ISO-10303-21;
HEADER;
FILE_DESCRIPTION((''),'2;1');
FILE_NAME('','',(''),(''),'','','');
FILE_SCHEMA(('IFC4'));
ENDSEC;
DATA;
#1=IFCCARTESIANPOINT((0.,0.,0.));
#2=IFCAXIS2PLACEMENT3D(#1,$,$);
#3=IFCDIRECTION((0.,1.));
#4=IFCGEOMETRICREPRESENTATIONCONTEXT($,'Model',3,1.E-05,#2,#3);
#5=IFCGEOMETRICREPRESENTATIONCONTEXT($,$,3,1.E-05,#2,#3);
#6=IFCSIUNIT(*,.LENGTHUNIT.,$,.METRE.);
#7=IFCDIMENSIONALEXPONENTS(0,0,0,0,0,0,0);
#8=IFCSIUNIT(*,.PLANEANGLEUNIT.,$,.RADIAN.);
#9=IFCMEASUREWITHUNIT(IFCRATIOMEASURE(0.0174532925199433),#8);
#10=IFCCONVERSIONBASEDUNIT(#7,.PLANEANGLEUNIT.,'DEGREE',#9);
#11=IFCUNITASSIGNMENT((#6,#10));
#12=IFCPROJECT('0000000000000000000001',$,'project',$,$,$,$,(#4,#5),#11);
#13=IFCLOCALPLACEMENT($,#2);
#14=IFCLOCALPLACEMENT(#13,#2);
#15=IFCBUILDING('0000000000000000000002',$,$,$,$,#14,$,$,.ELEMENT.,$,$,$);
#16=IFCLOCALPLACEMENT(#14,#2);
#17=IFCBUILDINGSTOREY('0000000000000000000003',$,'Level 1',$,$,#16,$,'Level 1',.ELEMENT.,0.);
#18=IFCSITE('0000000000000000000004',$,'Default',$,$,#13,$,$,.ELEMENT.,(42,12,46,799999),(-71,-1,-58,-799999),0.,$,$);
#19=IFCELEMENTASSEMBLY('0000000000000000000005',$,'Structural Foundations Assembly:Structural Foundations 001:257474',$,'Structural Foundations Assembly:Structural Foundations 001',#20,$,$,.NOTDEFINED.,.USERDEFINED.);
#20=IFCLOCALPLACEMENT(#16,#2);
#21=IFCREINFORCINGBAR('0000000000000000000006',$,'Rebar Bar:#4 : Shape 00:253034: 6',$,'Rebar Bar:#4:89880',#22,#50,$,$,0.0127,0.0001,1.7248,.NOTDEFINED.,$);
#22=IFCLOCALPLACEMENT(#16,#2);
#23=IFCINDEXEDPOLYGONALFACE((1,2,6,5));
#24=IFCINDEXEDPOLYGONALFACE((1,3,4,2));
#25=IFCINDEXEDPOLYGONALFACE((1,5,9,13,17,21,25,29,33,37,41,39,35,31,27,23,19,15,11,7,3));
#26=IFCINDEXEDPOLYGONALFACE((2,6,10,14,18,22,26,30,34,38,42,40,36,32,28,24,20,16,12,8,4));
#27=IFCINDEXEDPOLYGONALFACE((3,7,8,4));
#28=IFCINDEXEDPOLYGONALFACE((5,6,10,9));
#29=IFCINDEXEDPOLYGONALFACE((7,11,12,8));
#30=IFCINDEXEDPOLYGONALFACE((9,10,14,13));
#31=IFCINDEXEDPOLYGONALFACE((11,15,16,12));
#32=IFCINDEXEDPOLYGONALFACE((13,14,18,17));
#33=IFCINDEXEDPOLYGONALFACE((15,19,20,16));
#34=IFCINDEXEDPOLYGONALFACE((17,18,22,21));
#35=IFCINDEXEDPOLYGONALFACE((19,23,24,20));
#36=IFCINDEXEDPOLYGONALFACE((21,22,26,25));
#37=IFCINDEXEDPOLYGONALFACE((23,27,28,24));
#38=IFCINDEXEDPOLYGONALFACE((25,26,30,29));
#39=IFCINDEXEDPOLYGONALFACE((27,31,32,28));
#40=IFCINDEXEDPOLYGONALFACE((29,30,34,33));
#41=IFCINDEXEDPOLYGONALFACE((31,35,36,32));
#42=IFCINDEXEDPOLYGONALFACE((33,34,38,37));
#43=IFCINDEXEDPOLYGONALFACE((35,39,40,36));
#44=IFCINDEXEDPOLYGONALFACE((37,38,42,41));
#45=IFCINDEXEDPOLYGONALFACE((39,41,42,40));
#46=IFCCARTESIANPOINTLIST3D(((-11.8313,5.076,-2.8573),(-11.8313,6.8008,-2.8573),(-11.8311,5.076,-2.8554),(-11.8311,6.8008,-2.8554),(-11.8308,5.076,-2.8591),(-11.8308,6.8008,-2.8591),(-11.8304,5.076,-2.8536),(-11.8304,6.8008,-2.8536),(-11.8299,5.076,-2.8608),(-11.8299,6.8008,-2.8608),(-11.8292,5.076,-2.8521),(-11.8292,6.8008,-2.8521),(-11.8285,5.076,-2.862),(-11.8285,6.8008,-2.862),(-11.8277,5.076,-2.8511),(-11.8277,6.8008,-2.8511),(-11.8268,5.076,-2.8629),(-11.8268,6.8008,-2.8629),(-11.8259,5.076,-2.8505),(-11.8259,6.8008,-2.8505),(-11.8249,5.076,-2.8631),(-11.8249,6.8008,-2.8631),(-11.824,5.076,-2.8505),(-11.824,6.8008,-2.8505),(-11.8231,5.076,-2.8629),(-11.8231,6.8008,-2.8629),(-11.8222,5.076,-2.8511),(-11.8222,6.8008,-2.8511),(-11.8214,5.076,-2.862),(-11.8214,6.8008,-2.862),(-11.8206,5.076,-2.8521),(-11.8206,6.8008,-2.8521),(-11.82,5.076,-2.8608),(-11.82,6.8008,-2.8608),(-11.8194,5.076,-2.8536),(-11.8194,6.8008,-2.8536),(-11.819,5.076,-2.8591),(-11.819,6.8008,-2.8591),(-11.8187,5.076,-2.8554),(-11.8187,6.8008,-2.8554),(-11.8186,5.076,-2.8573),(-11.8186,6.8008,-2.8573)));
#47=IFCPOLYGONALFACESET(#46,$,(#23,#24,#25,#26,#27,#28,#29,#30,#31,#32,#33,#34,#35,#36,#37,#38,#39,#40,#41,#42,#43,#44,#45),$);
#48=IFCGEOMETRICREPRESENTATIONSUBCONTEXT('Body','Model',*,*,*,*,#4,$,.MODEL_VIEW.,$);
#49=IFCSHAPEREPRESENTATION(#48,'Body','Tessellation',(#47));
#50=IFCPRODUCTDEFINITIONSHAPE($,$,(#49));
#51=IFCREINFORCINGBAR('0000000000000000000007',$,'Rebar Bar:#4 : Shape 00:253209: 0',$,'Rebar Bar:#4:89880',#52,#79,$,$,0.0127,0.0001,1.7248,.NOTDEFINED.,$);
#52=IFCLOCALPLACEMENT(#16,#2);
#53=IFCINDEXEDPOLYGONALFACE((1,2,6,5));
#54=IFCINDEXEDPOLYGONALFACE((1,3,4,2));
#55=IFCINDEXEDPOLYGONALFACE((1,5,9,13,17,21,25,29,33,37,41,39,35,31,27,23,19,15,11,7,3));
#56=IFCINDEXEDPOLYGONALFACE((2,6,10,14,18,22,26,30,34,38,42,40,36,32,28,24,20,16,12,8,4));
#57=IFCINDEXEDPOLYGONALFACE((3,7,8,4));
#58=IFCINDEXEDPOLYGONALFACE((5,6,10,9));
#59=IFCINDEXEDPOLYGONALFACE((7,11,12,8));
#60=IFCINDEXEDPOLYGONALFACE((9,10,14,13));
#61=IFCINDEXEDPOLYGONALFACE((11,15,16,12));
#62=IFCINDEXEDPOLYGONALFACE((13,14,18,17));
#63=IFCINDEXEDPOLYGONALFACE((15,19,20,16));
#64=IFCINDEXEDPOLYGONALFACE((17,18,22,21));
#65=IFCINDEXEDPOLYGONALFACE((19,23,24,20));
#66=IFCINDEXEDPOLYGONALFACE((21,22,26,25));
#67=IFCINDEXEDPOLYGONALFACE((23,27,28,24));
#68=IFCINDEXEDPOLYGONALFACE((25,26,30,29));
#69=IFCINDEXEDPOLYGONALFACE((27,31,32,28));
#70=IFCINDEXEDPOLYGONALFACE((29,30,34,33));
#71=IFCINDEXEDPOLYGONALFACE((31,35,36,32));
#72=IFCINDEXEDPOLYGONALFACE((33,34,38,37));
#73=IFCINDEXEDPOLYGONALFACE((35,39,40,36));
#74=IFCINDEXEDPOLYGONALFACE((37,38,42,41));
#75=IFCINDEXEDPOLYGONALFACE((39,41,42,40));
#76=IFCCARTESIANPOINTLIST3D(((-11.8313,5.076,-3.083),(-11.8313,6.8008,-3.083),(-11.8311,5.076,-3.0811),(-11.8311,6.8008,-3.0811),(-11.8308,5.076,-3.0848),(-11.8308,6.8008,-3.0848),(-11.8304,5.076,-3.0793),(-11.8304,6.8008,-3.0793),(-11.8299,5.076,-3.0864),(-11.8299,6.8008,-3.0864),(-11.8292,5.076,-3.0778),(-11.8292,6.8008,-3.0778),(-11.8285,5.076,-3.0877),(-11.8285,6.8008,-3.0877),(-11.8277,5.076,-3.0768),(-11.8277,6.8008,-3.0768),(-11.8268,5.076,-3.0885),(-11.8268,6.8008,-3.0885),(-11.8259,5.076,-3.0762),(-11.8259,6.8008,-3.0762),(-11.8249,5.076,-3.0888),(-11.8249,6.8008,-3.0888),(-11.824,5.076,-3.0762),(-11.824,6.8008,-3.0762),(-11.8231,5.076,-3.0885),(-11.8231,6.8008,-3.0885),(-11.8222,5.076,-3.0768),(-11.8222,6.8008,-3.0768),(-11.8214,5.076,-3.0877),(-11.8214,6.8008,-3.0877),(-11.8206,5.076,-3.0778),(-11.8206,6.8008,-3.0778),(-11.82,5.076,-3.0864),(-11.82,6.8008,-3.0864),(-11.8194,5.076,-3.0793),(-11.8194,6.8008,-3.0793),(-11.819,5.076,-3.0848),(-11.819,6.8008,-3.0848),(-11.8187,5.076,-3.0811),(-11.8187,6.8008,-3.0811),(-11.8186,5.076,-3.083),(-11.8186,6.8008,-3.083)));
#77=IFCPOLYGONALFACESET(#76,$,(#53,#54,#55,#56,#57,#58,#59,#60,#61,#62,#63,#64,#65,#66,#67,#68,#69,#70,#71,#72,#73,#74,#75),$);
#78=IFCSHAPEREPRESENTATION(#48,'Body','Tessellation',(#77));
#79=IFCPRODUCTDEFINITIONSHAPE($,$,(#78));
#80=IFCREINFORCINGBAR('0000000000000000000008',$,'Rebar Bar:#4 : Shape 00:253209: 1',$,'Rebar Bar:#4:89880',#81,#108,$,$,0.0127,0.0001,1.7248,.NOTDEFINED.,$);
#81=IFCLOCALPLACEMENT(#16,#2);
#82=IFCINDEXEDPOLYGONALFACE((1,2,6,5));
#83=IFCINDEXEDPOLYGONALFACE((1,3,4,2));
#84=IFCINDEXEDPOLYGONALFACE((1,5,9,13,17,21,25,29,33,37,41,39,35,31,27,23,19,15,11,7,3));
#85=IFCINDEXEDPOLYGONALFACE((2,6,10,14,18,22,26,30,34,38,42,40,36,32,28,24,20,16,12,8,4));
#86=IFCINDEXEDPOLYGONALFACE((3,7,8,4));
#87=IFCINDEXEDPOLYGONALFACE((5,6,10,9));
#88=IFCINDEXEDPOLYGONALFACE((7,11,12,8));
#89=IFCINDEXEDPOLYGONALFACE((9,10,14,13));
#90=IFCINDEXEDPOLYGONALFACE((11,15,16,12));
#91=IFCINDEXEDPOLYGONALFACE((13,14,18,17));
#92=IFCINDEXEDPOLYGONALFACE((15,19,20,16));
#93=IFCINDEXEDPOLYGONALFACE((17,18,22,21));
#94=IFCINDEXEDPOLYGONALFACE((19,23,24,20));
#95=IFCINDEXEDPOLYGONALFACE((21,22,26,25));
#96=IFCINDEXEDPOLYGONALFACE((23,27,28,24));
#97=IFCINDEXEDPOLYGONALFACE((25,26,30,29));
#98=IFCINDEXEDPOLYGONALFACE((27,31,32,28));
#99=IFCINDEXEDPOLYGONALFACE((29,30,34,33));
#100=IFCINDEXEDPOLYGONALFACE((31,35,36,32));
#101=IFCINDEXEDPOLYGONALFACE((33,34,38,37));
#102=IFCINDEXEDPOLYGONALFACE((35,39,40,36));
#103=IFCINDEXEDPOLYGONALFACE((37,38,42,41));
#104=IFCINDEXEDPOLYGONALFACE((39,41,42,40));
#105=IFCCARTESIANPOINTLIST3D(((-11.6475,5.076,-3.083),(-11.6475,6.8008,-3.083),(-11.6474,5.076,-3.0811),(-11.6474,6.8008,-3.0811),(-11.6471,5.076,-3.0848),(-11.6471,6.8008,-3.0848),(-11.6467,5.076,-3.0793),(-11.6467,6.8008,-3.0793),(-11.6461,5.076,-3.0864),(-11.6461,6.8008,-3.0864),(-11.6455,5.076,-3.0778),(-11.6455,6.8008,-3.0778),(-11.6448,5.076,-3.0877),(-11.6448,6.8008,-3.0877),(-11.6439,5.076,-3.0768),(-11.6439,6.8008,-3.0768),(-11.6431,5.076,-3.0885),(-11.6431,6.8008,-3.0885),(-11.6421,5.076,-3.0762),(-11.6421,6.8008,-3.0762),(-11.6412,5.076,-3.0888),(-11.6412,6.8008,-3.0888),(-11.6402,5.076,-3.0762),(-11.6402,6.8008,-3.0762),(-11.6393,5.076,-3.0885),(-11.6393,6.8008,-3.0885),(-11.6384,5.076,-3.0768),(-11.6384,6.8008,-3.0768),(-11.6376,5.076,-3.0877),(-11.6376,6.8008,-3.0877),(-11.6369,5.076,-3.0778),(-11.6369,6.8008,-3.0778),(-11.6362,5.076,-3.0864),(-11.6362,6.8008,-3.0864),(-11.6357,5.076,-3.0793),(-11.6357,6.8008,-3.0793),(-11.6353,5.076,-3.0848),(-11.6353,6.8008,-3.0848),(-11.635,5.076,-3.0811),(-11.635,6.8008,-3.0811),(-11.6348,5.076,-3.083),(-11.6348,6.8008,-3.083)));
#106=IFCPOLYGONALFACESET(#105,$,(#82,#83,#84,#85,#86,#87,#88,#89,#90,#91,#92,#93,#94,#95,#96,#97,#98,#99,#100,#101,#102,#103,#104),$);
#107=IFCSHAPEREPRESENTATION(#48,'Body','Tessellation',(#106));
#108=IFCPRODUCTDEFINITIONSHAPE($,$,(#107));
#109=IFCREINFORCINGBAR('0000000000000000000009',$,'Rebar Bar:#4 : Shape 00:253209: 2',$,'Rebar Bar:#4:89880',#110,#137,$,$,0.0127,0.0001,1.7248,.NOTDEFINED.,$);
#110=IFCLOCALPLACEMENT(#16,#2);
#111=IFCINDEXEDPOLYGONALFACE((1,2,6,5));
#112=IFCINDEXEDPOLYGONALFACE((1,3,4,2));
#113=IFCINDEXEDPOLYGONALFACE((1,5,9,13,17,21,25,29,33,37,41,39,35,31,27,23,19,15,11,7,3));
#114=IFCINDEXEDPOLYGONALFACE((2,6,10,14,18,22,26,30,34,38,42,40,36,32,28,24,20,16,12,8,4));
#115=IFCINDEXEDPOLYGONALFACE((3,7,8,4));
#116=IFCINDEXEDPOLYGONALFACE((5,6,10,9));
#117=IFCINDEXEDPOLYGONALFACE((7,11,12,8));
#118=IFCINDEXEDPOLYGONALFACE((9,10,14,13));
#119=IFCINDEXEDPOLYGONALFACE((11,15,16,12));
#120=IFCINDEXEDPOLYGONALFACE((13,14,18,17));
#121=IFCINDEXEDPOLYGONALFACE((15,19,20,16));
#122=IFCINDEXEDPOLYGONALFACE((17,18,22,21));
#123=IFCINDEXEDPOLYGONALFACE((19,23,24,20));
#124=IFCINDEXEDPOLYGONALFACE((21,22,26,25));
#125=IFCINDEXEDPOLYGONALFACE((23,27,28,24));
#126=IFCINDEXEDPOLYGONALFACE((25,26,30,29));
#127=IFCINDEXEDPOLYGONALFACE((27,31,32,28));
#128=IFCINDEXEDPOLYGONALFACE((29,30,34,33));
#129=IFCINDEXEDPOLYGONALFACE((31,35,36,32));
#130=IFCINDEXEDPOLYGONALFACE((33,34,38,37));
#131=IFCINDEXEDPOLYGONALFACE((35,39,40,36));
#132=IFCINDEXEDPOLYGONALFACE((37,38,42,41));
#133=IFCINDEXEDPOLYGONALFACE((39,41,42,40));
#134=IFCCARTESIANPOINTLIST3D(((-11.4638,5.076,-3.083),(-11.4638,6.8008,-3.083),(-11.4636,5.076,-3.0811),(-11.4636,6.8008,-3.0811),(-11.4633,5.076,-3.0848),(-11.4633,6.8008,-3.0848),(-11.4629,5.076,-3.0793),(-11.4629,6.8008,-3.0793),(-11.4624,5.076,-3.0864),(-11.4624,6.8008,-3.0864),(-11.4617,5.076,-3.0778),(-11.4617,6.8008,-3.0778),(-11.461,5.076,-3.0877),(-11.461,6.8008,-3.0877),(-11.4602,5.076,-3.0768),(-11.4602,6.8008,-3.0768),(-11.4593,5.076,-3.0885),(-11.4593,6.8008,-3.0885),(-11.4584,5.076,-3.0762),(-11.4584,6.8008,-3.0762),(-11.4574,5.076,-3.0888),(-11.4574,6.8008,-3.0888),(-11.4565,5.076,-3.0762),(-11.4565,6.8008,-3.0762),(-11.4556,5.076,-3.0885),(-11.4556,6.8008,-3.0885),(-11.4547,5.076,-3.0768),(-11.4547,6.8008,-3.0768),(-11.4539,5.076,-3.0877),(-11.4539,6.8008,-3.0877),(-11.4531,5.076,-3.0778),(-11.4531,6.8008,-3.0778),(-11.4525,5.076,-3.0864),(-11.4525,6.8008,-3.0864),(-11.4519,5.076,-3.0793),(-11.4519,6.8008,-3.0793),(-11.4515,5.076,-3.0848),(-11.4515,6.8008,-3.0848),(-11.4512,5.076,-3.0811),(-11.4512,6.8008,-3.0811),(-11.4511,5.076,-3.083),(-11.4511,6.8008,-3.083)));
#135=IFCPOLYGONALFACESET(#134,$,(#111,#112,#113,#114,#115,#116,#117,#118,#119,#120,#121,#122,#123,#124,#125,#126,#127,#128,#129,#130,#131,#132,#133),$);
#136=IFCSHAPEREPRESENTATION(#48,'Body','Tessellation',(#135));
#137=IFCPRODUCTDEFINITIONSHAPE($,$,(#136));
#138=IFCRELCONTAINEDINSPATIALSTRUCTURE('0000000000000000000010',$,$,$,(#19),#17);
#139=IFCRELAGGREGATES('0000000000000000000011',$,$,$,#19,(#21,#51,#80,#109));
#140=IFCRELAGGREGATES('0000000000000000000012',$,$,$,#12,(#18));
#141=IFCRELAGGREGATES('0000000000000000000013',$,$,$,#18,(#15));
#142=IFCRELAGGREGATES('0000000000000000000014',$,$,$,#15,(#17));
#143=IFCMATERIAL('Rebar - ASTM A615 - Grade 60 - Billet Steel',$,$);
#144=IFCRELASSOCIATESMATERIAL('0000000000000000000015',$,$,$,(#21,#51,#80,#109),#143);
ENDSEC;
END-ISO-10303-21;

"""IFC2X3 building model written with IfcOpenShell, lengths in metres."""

from ifc_helpers import new_model, entity, si_unit, converted_unit, direction, origin, place, context, subcontext, project, spatial, material, element, aggregate, save


model = new_model("IFC2X3")

# Units and contexts
model_context = context("Model", 3, precision=1e-05, world=origin(), true_north=direction((0.0, 1.0)))
context_of_model = context(None, 3, precision=1e-05, world=origin(), true_north=direction((0.0, 1.0)))
body_context = subcontext(model_context, "Body", "Model", "MODEL_VIEW")
ifc_project = project(units=[si_unit("LENGTHUNIT", "METRE"), converted_unit("PLANEANGLEUNIT", "DEGREE", entity("IfcRatioMeasure", 0.0174532925199433), si_unit("PLANEANGLEUNIT", "RADIAN"), dimensions=[0, 0, 0, 0, 0, 0, 0])], contexts=[model_context, context_of_model])

# Site, building, storey
site_placement = place(None, origin())
site = spatial("IfcSite", under=ifc_project, at=site_placement, Name="Default", CompositionType="ELEMENT", RefLatitude=(42, 12, 46, 799999), RefLongitude=(-71, -1, -58, -799999), RefElevation=0.0)
building_placement = place(site_placement, origin())
building = spatial("IfcBuilding", under=site, at=building_placement, CompositionType="ELEMENT")
storey_placement = place(building_placement, origin())
storey = spatial("IfcBuildingStorey", under=building, at=storey_placement, Name="Level 1", LongName="Level 1", CompositionType="ELEMENT", Elevation=0.0)

# Element assembly, reinforcing bars
assembly_placement = place(storey_placement, origin())
assembly = element("IfcElementAssembly", 1, at=assembly_placement, inside=storey, Name="Structural Foundations Assembly:Structural Foundations 001:257474", ObjectType="Structural Foundations Assembly:Structural Foundations 001", AssemblyPlace="NOTDEFINED", PredefinedType="USERDEFINED")
ifc_material = material(Name="Rebar - ASTM A615 - Grade 60 - Billet Steel")
reinforcing_bar_1_placement = place(assembly_placement, origin())
reinforcing_bar_1 = element("IfcReinforcingBar", 2, at=reinforcing_bar_1_placement, material=ifc_material, Name="Rebar Bar:#4 : Shape 00:253034: 6", ObjectType="Rebar Bar:#4:89880", BarLength=1.7248, BarRole="NOTDEFINED", CrossSectionArea=0.0001, NominalDiameter=0.0127, context=body_context, shape_type="AdvancedSweptSolid", body=[
    entity("IfcSweptDiskSolid", entity("IfcCompositeCurve", [entity("IfcCompositeCurveSegment", "CONTINUOUS", True, entity("IfcPolyline", [entity("IfcCartesianPoint", [-11.8249, 6.8008, -2.8568]), entity("IfcCartesianPoint", [-11.8249, 5.076, -2.8568])]))], False), 0.0063, None, 0.0, 1.0),
])
reinforcing_bar_2_placement = place(assembly_placement, origin())
reinforcing_bar_2 = element("IfcReinforcingBar", 3, at=reinforcing_bar_2_placement, material=ifc_material, Name="Rebar Bar:#4 : Shape 00:253209: 0", ObjectType="Rebar Bar:#4:89880", BarLength=1.7248, BarRole="NOTDEFINED", CrossSectionArea=0.0001, NominalDiameter=0.0127, context=body_context, shape_type="AdvancedSweptSolid", body=[
    entity("IfcSweptDiskSolid", entity("IfcCompositeCurve", [entity("IfcCompositeCurveSegment", "CONTINUOUS", True, entity("IfcPolyline", [entity("IfcCartesianPoint", [-11.8249, 6.8008, -3.0825]), entity("IfcCartesianPoint", [-11.8249, 5.076, -3.0825])]))], False), 0.0063, None, 0.0, 1.0),
])
reinforcing_bar_3_placement = place(assembly_placement, origin())
reinforcing_bar_3 = element("IfcReinforcingBar", 4, at=reinforcing_bar_3_placement, material=ifc_material, Name="Rebar Bar:#4 : Shape 00:253209: 1", ObjectType="Rebar Bar:#4:89880", BarLength=1.7248, BarRole="NOTDEFINED", CrossSectionArea=0.0001, NominalDiameter=0.0127, context=body_context, shape_type="AdvancedSweptSolid", body=[
    entity("IfcSweptDiskSolid", entity("IfcCompositeCurve", [entity("IfcCompositeCurveSegment", "CONTINUOUS", True, entity("IfcPolyline", [entity("IfcCartesianPoint", [-11.6412, 6.8008, -3.0825]), entity("IfcCartesianPoint", [-11.6412, 5.076, -3.0825])]))], False), 0.0063, None, 0.0, 1.0),
])
reinforcing_bar_4_placement = place(assembly_placement, origin())
reinforcing_bar_4 = element("IfcReinforcingBar", 5, at=reinforcing_bar_4_placement, material=ifc_material, Name="Rebar Bar:#4 : Shape 00:253209: 2", ObjectType="Rebar Bar:#4:89880", BarLength=1.7248, BarRole="NOTDEFINED", CrossSectionArea=0.0001, NominalDiameter=0.0127, context=body_context, shape_type="AdvancedSweptSolid", body=[
    entity("IfcSweptDiskSolid", entity("IfcCompositeCurve", [entity("IfcCompositeCurveSegment", "CONTINUOUS", True, entity("IfcPolyline", [entity("IfcCartesianPoint", [-11.4574, 6.8008, -3.0825]), entity("IfcCartesianPoint", [-11.4574, 5.076, -3.0825])]))], False), 0.0063, None, 0.0, 1.0),
])
aggregate(assembly, [reinforcing_bar_1, reinforcing_bar_2, reinforcing_bar_3, reinforcing_bar_4])

save(model, "model.ifc")
